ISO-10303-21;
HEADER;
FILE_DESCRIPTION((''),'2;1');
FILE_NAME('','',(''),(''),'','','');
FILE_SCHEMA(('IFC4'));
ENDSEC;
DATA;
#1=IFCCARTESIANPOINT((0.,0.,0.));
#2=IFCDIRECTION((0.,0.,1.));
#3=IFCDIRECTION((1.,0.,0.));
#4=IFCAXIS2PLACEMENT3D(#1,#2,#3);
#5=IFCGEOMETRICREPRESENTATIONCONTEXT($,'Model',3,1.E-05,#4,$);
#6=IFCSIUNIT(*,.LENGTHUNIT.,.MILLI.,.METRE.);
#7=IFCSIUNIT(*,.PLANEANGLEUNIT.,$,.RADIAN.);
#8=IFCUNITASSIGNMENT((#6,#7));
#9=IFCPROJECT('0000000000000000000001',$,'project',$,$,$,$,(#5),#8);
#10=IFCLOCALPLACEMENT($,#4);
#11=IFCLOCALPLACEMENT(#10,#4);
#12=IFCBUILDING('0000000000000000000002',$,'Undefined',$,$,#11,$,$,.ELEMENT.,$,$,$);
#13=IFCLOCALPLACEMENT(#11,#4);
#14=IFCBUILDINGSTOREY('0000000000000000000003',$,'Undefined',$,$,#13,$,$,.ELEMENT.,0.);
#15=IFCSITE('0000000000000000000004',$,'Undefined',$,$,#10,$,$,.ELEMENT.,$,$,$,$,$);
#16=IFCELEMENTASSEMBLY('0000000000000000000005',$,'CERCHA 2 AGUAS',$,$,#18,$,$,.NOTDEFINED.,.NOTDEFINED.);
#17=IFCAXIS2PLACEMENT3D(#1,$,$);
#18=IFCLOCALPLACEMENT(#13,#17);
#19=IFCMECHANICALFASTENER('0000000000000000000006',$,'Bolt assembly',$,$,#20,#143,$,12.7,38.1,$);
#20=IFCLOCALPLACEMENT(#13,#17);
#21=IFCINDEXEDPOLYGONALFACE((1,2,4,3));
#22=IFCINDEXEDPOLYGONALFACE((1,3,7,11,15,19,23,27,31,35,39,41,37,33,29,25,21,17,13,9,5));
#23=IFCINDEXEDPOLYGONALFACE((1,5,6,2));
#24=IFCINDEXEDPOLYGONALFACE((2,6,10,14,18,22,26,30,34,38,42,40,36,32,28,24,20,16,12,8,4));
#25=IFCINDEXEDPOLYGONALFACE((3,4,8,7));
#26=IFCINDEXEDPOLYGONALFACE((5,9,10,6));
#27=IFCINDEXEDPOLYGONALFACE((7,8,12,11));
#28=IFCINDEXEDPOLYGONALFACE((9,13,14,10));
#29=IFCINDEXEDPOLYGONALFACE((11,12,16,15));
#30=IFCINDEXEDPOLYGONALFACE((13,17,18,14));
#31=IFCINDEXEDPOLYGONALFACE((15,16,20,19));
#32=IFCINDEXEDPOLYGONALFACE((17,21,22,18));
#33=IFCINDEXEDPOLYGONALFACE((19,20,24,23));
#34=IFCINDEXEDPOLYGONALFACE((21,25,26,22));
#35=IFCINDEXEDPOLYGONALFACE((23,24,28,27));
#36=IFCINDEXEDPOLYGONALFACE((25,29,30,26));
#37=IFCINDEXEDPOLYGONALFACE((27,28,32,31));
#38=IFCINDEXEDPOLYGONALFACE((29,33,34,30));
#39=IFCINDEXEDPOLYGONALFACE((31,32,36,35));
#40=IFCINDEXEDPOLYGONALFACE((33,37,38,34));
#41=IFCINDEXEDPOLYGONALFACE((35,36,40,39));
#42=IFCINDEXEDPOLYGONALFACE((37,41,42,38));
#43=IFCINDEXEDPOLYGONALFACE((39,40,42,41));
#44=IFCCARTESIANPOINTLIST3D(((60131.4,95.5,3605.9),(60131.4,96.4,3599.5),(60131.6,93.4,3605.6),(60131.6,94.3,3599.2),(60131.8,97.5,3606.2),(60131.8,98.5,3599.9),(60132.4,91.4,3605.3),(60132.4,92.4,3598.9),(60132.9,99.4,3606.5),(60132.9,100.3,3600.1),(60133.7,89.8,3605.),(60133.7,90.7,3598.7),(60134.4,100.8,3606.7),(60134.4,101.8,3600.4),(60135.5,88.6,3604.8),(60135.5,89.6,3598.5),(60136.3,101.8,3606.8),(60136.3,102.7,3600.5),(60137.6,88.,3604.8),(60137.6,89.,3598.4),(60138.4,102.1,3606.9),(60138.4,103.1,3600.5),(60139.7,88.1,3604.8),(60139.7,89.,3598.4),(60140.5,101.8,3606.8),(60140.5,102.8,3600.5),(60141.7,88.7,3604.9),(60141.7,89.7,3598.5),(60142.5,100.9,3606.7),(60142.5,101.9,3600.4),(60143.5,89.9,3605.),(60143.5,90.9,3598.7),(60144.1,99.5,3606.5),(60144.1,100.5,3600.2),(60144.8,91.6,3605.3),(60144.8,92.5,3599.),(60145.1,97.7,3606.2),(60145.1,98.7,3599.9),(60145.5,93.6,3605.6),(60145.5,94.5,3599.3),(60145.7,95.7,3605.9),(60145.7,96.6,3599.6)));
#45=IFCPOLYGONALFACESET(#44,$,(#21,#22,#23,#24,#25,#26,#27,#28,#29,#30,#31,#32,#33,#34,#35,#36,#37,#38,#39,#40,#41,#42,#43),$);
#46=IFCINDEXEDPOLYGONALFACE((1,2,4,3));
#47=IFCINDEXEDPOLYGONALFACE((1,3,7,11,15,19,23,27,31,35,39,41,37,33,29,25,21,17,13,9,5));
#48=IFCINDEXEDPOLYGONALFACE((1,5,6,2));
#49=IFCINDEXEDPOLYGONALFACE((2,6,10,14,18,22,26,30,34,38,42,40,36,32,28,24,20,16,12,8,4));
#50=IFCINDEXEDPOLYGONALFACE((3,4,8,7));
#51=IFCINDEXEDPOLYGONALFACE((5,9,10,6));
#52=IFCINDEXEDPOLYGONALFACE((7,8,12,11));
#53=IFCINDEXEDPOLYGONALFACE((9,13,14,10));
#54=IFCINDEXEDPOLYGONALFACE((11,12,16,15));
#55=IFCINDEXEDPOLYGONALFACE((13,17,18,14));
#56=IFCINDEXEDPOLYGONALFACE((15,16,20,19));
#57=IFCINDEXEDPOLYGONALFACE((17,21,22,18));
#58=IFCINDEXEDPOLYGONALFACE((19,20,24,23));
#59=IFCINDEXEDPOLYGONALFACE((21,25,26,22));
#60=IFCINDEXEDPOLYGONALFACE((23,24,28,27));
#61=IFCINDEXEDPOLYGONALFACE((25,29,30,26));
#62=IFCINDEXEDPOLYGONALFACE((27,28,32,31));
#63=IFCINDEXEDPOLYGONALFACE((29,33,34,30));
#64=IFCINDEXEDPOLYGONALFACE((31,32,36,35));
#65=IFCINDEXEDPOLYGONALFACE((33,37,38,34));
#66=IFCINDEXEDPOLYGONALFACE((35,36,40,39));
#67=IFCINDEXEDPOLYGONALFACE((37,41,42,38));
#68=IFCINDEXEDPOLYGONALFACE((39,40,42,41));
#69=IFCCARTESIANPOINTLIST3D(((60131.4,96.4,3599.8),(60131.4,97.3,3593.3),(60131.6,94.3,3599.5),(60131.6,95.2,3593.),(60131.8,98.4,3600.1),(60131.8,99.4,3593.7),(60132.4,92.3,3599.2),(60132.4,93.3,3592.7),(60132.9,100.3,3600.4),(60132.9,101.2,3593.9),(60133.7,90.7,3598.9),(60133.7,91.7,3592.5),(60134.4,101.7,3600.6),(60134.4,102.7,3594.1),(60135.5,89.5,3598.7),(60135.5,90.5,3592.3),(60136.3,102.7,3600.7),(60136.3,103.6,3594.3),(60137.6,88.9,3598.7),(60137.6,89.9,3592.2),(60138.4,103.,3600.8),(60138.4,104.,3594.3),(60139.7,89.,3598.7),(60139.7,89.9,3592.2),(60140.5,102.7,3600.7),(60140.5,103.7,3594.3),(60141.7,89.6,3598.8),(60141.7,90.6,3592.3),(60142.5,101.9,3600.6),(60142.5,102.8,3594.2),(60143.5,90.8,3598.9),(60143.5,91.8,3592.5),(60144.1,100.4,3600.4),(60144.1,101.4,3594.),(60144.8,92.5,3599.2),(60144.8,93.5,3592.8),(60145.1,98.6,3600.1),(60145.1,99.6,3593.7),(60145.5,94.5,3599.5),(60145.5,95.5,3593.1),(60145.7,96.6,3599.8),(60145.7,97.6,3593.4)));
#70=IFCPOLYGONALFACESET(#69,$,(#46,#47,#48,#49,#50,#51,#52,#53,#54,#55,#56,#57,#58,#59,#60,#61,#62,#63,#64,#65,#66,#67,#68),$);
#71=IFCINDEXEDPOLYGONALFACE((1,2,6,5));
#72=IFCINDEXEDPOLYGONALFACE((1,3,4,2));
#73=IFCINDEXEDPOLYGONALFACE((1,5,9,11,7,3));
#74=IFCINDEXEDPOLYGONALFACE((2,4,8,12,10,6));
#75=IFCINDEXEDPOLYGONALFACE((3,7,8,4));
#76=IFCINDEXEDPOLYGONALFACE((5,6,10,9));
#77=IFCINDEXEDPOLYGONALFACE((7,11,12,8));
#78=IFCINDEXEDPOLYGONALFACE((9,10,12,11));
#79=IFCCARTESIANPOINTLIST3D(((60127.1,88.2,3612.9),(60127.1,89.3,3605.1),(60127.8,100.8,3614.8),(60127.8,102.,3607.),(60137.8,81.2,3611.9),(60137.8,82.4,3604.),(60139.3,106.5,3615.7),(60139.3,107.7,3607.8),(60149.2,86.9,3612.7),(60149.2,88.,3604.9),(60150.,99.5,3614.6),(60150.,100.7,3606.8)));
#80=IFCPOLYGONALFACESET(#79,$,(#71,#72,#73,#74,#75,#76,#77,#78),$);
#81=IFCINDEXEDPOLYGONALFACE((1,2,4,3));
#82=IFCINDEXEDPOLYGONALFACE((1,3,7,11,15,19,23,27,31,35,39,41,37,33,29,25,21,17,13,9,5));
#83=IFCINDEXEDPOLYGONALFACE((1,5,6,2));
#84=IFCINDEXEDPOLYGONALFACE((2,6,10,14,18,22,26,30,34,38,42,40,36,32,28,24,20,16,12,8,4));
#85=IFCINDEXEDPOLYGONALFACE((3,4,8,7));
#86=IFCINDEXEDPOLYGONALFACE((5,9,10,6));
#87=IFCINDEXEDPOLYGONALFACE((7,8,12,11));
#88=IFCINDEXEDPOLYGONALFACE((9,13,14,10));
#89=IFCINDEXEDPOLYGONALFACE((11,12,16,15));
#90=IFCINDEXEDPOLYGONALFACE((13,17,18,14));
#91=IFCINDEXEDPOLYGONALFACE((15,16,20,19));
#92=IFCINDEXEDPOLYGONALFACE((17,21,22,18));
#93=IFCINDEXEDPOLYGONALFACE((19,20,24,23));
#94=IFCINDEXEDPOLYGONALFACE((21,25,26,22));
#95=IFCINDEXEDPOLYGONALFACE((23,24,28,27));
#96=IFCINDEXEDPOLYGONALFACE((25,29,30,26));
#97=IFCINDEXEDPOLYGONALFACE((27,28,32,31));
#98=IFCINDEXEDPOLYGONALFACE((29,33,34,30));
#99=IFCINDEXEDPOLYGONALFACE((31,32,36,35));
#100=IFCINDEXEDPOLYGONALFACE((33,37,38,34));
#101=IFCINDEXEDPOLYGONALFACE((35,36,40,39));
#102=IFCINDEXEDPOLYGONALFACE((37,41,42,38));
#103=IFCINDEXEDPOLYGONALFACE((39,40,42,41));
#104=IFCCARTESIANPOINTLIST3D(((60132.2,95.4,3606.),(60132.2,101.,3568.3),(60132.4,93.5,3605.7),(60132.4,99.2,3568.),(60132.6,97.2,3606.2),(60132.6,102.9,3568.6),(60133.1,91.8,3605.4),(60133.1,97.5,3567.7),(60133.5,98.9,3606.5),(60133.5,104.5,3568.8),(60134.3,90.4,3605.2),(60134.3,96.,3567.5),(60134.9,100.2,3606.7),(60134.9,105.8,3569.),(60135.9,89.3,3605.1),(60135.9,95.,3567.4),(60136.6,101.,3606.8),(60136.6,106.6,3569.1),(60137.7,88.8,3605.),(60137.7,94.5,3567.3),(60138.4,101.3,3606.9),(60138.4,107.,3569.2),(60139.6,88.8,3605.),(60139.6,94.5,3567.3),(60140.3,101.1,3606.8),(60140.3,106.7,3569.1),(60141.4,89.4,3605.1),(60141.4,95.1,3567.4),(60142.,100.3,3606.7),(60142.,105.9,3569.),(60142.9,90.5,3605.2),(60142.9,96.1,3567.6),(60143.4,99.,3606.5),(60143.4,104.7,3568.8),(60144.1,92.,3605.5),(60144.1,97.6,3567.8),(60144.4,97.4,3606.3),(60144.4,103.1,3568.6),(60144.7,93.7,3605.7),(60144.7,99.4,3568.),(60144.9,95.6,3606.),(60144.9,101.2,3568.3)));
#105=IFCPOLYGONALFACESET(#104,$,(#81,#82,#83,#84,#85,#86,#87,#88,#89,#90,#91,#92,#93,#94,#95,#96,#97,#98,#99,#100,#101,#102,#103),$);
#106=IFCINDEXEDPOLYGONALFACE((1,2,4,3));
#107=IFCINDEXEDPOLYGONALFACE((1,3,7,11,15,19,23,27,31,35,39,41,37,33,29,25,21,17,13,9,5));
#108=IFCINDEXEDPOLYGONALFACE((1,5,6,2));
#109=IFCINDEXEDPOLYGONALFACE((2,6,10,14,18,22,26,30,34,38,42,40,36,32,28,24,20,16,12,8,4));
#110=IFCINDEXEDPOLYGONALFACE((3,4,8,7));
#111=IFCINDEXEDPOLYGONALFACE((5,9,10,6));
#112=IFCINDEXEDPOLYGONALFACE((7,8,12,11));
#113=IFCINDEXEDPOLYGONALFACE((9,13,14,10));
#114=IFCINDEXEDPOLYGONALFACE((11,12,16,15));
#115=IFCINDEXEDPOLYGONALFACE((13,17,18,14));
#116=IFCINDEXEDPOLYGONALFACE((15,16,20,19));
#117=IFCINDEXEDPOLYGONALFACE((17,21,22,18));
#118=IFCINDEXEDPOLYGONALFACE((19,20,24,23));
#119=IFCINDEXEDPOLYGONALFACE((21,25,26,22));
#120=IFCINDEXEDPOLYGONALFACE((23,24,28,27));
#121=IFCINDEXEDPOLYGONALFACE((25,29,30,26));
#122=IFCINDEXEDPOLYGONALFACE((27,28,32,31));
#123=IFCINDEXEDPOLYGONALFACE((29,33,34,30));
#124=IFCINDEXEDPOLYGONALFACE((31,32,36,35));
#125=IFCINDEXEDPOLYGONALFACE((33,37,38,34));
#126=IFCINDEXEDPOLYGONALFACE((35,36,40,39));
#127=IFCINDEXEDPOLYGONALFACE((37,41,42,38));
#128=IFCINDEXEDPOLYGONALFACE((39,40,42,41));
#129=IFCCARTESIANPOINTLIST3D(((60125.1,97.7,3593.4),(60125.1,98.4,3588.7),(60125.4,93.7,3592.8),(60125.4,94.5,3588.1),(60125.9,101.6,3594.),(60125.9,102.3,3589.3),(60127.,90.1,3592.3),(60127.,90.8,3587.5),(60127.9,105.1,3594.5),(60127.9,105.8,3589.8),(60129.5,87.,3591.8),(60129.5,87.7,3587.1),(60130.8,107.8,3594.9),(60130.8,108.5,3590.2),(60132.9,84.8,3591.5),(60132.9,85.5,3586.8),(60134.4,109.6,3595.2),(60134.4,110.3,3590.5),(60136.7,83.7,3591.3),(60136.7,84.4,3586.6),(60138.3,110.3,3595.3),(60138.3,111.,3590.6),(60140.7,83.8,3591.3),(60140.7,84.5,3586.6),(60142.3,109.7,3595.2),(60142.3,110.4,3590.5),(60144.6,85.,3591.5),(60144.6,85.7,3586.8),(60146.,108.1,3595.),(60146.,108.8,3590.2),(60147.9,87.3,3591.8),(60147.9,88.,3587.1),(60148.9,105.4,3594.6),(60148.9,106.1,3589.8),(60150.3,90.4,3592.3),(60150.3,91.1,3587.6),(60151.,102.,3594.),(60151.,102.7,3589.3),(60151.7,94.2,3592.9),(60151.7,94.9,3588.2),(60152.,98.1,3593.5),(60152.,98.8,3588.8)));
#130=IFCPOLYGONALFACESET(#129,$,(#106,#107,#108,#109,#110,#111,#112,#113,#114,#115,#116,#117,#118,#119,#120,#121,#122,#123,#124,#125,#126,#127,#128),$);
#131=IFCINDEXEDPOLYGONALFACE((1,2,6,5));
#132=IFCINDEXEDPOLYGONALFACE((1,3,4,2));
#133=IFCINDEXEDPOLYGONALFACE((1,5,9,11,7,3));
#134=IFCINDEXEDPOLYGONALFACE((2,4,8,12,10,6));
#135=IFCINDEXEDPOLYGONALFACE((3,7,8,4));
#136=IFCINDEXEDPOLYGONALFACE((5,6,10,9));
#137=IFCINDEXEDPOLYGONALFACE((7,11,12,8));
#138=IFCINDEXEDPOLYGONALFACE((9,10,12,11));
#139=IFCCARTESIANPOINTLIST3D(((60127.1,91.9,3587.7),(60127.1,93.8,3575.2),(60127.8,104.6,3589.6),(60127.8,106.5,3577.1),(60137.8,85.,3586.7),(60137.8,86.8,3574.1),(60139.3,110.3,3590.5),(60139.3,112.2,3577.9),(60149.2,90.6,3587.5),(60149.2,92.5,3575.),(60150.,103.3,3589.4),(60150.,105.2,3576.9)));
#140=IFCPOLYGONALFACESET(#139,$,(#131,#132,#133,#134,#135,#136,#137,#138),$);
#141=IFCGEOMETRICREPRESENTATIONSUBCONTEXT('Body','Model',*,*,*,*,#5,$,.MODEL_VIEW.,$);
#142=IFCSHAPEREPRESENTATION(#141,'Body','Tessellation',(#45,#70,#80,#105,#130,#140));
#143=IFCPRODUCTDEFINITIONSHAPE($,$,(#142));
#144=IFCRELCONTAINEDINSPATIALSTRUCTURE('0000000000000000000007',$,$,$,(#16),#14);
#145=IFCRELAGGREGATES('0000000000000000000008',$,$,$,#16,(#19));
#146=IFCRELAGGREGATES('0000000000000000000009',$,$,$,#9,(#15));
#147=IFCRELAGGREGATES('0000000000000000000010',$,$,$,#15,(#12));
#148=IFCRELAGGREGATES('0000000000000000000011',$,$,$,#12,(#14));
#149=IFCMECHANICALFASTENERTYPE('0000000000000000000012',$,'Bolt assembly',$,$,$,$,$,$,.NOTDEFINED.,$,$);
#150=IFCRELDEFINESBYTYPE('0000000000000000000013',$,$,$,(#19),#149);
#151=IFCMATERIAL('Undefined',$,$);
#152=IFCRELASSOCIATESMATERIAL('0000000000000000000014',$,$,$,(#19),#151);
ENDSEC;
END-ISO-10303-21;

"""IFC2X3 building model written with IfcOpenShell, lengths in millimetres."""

from ifc_helpers import new_model, si_unit, frame, origin_with_axes, origin_2d_with_axis, place, context, subcontext, project, spatial, polyline, circle, outline, extrude, source, transform, mapped, material, type_object, element, aggregate, save


model = new_model("IFC2X3")

# Units and contexts
model_context = context("Model", 3, precision=1e-05, world=origin_with_axes())
body_context = subcontext(model_context, "Body", "Model", "MODEL_VIEW")
ifc_project = project(units=[si_unit("LENGTHUNIT", "METRE", prefix="MILLI"), si_unit("PLANEANGLEUNIT", "RADIAN")], contexts=[model_context])

# Site, building, storey
site_placement = place(None, origin_with_axes())
site = spatial("IfcSite", under=ifc_project, at=site_placement, Name="Undefined", CompositionType="ELEMENT")
building_placement = place(site_placement, origin_with_axes())
building = spatial("IfcBuilding", under=site, at=building_placement, Name="Undefined", CompositionType="ELEMENT")
storey_placement = place(building_placement, origin_with_axes())
storey = spatial("IfcBuildingStorey", under=building, at=storey_placement, Name="Undefined", CompositionType="ELEMENT", Elevation=0.0)

# Element assembly
assembly_1_placement = place(storey_placement, origin_with_axes())
assembly_1 = element("IfcElementAssembly", 1, at=assembly_1_placement, inside=storey, Name="CERCHA 2 AGUAS", AssemblyPlace="NOTDEFINED", PredefinedType="NOTDEFINED")

# Shared definitions
ifc_material_1 = material(Name="Undefined")
mechanical_fastener_type = type_object("IfcMechanicalFastenerType", Name="Bolt assembly")

# Mechanical fastener
shared_shape_1 = source(origin_with_axes(), body_context, "Body", "SweptSolid", [
    extrude(circle(Radius=7.1, at=origin_2d_with_axis()), frame((0.0, -6.3, 0.0), z_axis=(0.0, 1.0, 0.0), x_axis=(1.0, 0.0, 0.0)), (0.0, 0.0, 1.0), 6.4),
    extrude(circle(Radius=7.1, at=origin_2d_with_axis()), frame((0.0, -0.1, 0.0), z_axis=(0.0, 1.0, 0.0), x_axis=(1.0, 0.0, 0.0)), (0.0, 0.0, 1.0), 6.5),
    extrude(outline(polyline([(11.1, -6.4), (11.1, 6.4), (0.0, 12.8), (-11.1, 6.4), (-11.1, -6.4), (0.0, -12.8), (11.1, -6.4)])), frame((0.0, -14.3, 0.0), z_axis=(0.0, 1.0, 0.0), x_axis=(1.0, 0.0, 0.0)), (0.0, 0.0, 1.0), 7.9),
    extrude(circle(Radius=6.3, at=origin_2d_with_axis()), frame((0.0, -6.4, 0.0), z_axis=(0.0, 1.0, 0.0), x_axis=(1.0, 0.0, 0.0)), (0.0, 0.0, 1.0), 38.1),
    extrude(circle(Radius=13.5, at=origin_2d_with_axis()), frame((0.0, 6.4, 0.0), z_axis=(0.0, 1.0, 0.0), x_axis=(1.0, 0.0, 0.0)), (0.0, 0.0, 1.0), 4.8),
    extrude(outline(polyline([(11.1, -6.4), (11.1, 6.4), (0.0, 12.8), (-11.1, 6.4), (-11.1, -6.4), (0.0, -12.8), (11.1, -6.4)])), frame((0.0, 11.2, 0.0), z_axis=(0.0, 1.0, 0.0), x_axis=(1.0, 0.0, 0.0)), (0.0, 0.0, 1.0), 12.7),
])
mechanical_fastener_1_placement = place(assembly_1_placement, frame((60138.5, 96.0, 3599.6), z_axis=(-0.834881, 0.544341, 0.081651), x_axis=(0.55043, 0.825644, 0.123847)))
mechanical_fastener_1 = element("IfcMechanicalFastener", 2, at=mechanical_fastener_1_placement, type_object=mechanical_fastener_type, material=ifc_material_1, Name="Bolt assembly", NominalDiameter=12.7, NominalLength=38.1, context=body_context, shape_type="MappedRepresentation", body=[
    mapped(shared_shape_1, transform((0.0, 0.0, 0.0))),
])

aggregate(assembly_1, [mechanical_fastener_1])

save(model, "model.ifc")
